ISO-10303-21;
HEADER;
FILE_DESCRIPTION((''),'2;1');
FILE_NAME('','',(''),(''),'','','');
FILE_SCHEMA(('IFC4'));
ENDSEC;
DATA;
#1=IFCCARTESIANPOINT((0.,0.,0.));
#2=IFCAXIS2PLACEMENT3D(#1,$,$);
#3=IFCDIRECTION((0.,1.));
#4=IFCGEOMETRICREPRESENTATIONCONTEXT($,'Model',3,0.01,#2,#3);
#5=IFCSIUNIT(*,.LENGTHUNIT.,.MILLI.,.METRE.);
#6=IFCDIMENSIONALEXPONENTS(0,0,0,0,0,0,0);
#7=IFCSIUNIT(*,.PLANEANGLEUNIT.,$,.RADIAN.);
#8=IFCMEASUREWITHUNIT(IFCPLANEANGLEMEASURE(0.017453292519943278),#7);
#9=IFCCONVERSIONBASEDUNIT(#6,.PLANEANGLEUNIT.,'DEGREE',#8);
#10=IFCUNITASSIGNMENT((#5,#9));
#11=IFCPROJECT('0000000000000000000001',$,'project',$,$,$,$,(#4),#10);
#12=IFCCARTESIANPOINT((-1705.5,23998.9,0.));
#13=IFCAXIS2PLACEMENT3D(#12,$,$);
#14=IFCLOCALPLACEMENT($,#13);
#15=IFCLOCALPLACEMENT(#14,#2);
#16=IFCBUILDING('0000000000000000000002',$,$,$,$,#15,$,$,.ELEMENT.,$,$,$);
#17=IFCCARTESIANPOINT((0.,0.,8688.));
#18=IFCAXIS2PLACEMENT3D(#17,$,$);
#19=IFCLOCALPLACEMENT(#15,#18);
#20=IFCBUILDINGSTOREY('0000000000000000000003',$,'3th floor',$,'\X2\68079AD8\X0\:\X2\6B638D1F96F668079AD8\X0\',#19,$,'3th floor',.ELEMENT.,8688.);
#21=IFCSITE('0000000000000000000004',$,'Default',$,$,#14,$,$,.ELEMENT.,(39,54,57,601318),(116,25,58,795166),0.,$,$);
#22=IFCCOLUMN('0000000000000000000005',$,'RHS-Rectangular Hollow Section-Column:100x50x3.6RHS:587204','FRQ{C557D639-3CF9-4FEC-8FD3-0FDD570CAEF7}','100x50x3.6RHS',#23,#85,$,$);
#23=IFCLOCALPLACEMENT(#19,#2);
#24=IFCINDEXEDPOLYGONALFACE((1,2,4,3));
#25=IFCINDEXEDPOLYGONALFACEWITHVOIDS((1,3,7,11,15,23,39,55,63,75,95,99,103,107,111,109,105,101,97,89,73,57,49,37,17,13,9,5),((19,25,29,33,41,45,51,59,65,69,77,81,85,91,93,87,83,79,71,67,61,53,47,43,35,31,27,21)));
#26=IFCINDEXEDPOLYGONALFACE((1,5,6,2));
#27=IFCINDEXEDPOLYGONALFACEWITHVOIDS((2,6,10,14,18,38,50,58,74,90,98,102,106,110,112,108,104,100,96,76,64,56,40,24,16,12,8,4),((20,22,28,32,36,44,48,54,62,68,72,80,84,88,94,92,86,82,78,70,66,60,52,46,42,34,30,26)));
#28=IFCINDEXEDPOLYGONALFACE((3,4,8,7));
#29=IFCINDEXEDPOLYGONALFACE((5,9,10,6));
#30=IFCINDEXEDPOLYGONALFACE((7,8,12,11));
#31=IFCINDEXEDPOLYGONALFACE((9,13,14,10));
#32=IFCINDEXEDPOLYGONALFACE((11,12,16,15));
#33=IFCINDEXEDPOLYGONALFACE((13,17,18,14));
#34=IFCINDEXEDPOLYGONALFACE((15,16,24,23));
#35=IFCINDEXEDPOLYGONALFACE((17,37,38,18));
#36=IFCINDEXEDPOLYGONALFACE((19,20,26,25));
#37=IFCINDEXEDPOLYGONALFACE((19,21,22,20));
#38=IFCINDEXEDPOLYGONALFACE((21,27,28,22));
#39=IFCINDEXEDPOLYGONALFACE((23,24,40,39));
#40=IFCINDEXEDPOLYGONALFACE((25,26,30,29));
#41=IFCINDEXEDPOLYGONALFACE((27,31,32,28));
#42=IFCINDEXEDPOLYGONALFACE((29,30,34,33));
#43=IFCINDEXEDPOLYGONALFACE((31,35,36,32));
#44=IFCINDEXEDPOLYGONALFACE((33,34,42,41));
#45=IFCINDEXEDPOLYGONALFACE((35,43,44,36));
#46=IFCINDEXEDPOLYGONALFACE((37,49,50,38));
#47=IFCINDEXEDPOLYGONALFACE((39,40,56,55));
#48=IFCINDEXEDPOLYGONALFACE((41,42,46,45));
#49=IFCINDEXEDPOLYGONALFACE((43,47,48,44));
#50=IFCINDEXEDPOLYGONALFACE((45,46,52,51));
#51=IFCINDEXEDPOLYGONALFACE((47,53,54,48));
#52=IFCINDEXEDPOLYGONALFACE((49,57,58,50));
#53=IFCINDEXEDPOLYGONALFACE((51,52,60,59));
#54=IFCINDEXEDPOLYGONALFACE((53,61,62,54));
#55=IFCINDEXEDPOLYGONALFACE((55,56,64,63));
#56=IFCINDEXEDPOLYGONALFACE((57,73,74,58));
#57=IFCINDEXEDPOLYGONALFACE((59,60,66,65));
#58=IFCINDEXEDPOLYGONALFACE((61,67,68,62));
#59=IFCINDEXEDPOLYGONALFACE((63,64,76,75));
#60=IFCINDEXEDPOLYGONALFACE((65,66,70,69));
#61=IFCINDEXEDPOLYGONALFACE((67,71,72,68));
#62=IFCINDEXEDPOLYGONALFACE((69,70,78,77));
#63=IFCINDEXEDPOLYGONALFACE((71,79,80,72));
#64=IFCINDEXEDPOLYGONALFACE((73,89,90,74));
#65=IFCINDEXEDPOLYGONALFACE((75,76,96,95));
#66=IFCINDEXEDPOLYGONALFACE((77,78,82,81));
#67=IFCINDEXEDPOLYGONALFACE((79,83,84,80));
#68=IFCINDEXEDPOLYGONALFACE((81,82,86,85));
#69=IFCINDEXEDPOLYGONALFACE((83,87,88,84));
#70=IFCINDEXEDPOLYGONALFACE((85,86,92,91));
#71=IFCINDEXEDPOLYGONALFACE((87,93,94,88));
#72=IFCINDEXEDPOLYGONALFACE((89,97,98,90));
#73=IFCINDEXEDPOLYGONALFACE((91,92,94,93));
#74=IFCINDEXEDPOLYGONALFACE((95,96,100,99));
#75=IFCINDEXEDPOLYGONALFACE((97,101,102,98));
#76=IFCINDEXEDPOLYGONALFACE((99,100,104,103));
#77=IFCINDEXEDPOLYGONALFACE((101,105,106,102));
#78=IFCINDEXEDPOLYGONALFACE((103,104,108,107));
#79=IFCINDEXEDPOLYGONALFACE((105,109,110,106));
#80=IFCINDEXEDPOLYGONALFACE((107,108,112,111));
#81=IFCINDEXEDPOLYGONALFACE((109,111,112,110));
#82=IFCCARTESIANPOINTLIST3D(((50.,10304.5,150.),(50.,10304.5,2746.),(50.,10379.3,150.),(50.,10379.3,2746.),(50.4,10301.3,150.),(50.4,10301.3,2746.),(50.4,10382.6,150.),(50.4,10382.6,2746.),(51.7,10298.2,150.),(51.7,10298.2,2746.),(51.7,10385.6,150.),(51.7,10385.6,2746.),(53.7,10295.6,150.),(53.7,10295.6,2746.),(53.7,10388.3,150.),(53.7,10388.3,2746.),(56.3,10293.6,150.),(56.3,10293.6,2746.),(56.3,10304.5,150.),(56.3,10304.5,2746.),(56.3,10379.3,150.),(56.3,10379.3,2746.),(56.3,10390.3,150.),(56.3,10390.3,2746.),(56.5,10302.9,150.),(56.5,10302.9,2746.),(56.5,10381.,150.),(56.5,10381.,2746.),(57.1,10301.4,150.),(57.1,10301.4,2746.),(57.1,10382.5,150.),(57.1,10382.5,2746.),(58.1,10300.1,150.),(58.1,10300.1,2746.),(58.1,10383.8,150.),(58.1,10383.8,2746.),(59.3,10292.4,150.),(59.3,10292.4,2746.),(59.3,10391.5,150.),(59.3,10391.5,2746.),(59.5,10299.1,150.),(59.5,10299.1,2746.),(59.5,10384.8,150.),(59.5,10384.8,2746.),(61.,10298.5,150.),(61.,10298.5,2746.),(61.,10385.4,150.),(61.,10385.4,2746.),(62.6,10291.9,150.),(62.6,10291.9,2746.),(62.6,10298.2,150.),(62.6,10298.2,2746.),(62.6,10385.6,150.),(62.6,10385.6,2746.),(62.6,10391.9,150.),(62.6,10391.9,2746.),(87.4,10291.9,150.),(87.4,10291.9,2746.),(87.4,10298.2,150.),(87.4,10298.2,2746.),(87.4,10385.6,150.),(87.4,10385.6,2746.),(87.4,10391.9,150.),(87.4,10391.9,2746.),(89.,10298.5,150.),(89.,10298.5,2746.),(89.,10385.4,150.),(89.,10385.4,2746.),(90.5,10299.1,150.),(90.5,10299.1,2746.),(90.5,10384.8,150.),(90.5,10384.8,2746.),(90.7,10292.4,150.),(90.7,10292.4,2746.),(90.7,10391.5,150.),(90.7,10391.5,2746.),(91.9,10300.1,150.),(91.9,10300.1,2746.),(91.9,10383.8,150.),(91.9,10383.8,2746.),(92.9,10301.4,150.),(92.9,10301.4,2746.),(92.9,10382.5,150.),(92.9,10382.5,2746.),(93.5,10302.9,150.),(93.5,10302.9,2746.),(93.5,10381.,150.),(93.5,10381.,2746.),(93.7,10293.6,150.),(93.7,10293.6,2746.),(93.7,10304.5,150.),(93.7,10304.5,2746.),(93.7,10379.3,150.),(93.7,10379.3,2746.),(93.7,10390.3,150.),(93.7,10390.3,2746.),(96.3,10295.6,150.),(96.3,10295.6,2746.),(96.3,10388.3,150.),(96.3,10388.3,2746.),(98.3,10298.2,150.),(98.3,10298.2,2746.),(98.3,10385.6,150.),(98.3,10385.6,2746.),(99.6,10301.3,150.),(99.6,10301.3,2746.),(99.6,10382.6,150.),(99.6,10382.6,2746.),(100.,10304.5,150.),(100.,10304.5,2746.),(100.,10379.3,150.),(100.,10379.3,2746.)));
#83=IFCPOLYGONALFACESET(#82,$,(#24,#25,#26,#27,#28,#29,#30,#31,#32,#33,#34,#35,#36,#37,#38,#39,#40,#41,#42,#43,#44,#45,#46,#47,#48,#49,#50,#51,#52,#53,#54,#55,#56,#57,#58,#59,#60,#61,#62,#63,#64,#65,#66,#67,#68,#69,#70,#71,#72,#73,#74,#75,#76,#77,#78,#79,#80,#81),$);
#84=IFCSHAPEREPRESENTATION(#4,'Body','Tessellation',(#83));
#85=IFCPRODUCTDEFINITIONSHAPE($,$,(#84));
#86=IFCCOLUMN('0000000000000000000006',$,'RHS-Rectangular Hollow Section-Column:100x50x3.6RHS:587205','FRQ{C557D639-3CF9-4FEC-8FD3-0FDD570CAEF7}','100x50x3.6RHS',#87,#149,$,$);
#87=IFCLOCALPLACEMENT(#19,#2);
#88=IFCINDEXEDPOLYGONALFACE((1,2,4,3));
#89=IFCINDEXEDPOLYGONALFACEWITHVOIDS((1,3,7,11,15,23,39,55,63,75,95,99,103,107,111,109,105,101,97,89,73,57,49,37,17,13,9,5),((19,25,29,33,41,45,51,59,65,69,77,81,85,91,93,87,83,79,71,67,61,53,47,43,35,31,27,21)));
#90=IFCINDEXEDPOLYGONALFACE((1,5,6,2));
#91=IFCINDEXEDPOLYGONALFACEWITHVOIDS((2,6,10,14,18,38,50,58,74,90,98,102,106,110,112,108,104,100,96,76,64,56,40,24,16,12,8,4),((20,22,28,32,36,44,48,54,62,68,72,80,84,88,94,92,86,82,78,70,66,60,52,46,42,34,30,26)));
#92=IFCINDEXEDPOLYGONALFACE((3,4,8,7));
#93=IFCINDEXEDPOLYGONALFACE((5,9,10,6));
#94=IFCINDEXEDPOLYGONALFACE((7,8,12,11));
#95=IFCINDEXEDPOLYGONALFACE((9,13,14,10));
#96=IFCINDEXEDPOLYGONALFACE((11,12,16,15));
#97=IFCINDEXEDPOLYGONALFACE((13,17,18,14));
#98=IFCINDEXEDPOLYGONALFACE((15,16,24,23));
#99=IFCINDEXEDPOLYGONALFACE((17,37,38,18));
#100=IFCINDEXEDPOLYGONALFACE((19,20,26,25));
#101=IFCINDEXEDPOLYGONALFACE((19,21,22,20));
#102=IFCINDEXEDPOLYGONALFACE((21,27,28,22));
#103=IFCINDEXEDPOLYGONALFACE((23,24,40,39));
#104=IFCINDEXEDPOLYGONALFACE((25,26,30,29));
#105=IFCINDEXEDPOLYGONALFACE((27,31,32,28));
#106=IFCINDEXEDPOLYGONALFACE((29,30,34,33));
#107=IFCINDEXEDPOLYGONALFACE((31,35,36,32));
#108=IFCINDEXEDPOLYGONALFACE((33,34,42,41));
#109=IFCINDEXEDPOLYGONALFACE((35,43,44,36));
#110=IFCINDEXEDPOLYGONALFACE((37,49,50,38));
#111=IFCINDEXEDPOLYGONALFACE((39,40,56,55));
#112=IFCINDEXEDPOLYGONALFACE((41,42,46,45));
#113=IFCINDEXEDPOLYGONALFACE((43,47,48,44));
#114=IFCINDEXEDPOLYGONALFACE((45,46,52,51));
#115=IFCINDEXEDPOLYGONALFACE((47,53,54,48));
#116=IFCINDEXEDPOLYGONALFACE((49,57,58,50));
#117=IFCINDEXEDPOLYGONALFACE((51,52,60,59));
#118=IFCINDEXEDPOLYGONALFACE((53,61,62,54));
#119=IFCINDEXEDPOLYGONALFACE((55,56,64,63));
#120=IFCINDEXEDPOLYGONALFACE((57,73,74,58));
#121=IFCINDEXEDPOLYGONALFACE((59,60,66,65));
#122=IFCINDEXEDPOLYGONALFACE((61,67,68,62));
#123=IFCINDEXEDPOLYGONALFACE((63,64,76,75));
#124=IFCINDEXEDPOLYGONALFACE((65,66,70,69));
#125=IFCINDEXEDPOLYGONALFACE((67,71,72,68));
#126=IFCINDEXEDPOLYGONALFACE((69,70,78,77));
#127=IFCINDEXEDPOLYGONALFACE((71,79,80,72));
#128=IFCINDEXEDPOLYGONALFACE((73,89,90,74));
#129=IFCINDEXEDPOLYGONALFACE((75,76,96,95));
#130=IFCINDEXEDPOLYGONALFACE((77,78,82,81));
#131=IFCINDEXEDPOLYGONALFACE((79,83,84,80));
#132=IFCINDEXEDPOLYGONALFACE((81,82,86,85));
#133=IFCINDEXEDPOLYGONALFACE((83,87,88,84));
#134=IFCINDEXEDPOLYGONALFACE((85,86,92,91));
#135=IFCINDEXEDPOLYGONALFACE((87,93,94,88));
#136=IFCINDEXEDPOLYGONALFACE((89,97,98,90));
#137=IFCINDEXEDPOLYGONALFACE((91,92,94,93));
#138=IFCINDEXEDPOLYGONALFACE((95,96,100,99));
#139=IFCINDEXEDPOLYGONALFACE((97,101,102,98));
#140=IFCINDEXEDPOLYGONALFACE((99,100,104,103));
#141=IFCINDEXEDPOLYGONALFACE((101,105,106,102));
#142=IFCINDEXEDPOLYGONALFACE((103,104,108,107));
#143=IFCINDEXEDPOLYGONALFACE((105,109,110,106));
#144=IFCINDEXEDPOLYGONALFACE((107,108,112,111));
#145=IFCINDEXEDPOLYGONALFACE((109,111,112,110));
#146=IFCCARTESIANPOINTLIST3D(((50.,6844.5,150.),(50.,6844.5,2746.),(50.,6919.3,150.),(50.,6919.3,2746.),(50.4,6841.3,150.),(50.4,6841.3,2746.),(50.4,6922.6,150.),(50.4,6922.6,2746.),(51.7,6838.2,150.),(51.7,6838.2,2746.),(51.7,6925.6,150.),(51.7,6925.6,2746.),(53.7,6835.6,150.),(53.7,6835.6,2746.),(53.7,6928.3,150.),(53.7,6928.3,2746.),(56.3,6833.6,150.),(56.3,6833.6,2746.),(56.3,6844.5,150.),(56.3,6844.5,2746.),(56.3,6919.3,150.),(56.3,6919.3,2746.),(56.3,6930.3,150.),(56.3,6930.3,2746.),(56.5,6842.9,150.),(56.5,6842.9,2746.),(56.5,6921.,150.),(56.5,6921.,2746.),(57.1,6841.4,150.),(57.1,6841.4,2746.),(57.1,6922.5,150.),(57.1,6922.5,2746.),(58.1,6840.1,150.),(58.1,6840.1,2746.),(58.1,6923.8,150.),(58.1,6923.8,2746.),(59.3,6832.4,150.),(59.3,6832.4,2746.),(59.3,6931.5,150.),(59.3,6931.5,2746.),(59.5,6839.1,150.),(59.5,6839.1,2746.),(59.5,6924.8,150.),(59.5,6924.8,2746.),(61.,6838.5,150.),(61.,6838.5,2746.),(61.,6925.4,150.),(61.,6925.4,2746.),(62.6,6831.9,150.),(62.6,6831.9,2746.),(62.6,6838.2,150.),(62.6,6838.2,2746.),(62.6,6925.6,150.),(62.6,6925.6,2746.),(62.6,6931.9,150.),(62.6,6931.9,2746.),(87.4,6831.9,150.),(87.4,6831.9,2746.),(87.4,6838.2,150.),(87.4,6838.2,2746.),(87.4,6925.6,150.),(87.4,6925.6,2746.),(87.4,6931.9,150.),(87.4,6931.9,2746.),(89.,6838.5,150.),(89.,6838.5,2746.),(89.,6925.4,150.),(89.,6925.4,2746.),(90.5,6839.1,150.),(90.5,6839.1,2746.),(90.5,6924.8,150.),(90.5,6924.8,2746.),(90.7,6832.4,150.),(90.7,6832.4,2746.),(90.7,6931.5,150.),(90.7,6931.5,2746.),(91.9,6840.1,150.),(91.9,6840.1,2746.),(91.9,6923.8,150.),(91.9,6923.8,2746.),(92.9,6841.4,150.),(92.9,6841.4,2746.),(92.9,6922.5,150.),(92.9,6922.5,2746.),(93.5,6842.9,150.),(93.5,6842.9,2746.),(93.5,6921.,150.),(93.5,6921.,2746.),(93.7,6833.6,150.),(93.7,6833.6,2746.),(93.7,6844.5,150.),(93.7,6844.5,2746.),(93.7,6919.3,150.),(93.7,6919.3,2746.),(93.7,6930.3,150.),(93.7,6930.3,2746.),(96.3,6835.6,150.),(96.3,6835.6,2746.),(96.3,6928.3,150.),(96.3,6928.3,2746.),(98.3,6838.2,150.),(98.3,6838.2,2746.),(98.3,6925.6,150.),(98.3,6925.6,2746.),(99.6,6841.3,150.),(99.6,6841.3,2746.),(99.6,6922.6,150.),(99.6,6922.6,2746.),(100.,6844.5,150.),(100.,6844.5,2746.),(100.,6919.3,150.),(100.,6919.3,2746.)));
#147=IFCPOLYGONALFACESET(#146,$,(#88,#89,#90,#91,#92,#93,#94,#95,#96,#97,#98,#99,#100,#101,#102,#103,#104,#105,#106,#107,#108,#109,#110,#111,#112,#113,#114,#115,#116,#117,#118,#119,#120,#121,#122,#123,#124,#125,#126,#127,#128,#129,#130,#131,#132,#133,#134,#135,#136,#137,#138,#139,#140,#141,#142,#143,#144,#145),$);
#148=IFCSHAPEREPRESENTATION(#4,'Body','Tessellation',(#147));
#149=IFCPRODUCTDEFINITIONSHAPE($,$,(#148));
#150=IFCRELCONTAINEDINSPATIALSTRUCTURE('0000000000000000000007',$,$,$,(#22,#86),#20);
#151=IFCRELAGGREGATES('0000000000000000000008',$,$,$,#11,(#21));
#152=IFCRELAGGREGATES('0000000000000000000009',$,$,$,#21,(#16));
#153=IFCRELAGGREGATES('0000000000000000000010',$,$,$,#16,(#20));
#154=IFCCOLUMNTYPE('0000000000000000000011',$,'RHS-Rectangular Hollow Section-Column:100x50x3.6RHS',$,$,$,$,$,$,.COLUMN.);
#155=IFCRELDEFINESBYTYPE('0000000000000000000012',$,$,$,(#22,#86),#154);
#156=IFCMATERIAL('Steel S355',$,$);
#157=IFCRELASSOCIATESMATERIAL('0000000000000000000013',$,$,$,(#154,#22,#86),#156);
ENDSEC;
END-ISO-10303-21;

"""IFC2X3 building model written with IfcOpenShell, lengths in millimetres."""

from ifc_helpers import new_model, entity, si_unit, converted_unit, direction, frame, origin, origin_2d, place, context, project, spatial, hollow_rectangle, extrude, clip, halfspace, material, type_object, element, save


model = new_model("IFC2X3")

# Units and contexts
model_context = context("Model", 3, precision=0.01, world=origin(), true_north=direction((0.0, 1.0)))
ifc_project = project(units=[si_unit("LENGTHUNIT", "METRE", prefix="MILLI"), converted_unit("PLANEANGLEUNIT", "DEGREE", entity("IfcPlaneAngleMeasure", 0.017453292519943278), si_unit("PLANEANGLEUNIT", "RADIAN"), dimensions=[0, 0, 0, 0, 0, 0, 0])], contexts=[model_context])

# Site, building, storey
site_placement = place(None, frame((-1705.5, 23998.9, 0.0)))
site = spatial("IfcSite", under=ifc_project, at=site_placement, Name="Default", CompositionType="ELEMENT", RefLatitude=(39, 54, 57, 601318), RefLongitude=(116, 25, 58, 795166), RefElevation=0.0)
building_placement = place(site_placement, origin())
building = spatial("IfcBuilding", under=site, at=building_placement, CompositionType="ELEMENT")
storey_placement = place(building_placement, frame((0.0, 0.0, 8688.0)))
storey = spatial("IfcBuildingStorey", under=building, at=storey_placement, Name="3th floor", ObjectType="标高:正负零标高", LongName="3th floor", CompositionType="ELEMENT", Elevation=8688.0)

# Columns
ifc_material_1 = material(Name="Steel S355")
column_type_1 = type_object("IfcColumnType", Name="RHS-Rectangular Hollow Section-Column:100x50x3.6RHS", PredefinedType="COLUMN", material=ifc_material_1)
column_1_placement = place(storey_placement, frame((75.0, 10341.9, 2746.0), z_axis=(0.0, 0.0, 1.0), x_axis=(-1.0, 0.0, 0.0)))
element("IfcColumn", 1, at=column_1_placement, inside=storey, type_object=column_type_1, material=ifc_material_1, Name="RHS-Rectangular Hollow Section-Column:100x50x3.6RHS:587204", Description="FRQ{C557D639-3CF9-4FEC-8FD3-0FDD570CAEF7}", ObjectType="100x50x3.6RHS", context=model_context, shape_type="Clipping", body=[
    clip(extrude(hollow_rectangle(XDim=50.0, YDim=100.0, WallThickness=6.3, InnerFilletRadius=6.3, OuterFilletRadius=12.6, at=origin_2d()), origin(), (0.0, 0.0, -1.0), 2651.9), halfspace(frame((75.0, 10341.9, -2596.0), z_axis=(0.0, 0.0, 1.0), x_axis=(-1.0, 0.0, 0.0)), True)),
])
column_2_placement = place(storey_placement, frame((75.0, 6881.9, 2746.0), z_axis=(0.0, 0.0, 1.0), x_axis=(-1.0, 0.0, 0.0)))
element("IfcColumn", 2, at=column_2_placement, inside=storey, type_object=column_type_1, material=ifc_material_1, Name="RHS-Rectangular Hollow Section-Column:100x50x3.6RHS:587205", Description="FRQ{C557D639-3CF9-4FEC-8FD3-0FDD570CAEF7}", ObjectType="100x50x3.6RHS", context=model_context, shape_type="Clipping", body=[
    clip(extrude(hollow_rectangle(XDim=50.0, YDim=100.0, WallThickness=6.3, InnerFilletRadius=6.3, OuterFilletRadius=12.6, at=origin_2d()), origin(), (0.0, 0.0, -1.0), 2651.9), halfspace(frame((75.0, 6881.9, -2596.0), z_axis=(0.0, 0.0, 1.0), x_axis=(-1.0, 0.0, 0.0)), True)),
])

save(model, "model.ifc")
